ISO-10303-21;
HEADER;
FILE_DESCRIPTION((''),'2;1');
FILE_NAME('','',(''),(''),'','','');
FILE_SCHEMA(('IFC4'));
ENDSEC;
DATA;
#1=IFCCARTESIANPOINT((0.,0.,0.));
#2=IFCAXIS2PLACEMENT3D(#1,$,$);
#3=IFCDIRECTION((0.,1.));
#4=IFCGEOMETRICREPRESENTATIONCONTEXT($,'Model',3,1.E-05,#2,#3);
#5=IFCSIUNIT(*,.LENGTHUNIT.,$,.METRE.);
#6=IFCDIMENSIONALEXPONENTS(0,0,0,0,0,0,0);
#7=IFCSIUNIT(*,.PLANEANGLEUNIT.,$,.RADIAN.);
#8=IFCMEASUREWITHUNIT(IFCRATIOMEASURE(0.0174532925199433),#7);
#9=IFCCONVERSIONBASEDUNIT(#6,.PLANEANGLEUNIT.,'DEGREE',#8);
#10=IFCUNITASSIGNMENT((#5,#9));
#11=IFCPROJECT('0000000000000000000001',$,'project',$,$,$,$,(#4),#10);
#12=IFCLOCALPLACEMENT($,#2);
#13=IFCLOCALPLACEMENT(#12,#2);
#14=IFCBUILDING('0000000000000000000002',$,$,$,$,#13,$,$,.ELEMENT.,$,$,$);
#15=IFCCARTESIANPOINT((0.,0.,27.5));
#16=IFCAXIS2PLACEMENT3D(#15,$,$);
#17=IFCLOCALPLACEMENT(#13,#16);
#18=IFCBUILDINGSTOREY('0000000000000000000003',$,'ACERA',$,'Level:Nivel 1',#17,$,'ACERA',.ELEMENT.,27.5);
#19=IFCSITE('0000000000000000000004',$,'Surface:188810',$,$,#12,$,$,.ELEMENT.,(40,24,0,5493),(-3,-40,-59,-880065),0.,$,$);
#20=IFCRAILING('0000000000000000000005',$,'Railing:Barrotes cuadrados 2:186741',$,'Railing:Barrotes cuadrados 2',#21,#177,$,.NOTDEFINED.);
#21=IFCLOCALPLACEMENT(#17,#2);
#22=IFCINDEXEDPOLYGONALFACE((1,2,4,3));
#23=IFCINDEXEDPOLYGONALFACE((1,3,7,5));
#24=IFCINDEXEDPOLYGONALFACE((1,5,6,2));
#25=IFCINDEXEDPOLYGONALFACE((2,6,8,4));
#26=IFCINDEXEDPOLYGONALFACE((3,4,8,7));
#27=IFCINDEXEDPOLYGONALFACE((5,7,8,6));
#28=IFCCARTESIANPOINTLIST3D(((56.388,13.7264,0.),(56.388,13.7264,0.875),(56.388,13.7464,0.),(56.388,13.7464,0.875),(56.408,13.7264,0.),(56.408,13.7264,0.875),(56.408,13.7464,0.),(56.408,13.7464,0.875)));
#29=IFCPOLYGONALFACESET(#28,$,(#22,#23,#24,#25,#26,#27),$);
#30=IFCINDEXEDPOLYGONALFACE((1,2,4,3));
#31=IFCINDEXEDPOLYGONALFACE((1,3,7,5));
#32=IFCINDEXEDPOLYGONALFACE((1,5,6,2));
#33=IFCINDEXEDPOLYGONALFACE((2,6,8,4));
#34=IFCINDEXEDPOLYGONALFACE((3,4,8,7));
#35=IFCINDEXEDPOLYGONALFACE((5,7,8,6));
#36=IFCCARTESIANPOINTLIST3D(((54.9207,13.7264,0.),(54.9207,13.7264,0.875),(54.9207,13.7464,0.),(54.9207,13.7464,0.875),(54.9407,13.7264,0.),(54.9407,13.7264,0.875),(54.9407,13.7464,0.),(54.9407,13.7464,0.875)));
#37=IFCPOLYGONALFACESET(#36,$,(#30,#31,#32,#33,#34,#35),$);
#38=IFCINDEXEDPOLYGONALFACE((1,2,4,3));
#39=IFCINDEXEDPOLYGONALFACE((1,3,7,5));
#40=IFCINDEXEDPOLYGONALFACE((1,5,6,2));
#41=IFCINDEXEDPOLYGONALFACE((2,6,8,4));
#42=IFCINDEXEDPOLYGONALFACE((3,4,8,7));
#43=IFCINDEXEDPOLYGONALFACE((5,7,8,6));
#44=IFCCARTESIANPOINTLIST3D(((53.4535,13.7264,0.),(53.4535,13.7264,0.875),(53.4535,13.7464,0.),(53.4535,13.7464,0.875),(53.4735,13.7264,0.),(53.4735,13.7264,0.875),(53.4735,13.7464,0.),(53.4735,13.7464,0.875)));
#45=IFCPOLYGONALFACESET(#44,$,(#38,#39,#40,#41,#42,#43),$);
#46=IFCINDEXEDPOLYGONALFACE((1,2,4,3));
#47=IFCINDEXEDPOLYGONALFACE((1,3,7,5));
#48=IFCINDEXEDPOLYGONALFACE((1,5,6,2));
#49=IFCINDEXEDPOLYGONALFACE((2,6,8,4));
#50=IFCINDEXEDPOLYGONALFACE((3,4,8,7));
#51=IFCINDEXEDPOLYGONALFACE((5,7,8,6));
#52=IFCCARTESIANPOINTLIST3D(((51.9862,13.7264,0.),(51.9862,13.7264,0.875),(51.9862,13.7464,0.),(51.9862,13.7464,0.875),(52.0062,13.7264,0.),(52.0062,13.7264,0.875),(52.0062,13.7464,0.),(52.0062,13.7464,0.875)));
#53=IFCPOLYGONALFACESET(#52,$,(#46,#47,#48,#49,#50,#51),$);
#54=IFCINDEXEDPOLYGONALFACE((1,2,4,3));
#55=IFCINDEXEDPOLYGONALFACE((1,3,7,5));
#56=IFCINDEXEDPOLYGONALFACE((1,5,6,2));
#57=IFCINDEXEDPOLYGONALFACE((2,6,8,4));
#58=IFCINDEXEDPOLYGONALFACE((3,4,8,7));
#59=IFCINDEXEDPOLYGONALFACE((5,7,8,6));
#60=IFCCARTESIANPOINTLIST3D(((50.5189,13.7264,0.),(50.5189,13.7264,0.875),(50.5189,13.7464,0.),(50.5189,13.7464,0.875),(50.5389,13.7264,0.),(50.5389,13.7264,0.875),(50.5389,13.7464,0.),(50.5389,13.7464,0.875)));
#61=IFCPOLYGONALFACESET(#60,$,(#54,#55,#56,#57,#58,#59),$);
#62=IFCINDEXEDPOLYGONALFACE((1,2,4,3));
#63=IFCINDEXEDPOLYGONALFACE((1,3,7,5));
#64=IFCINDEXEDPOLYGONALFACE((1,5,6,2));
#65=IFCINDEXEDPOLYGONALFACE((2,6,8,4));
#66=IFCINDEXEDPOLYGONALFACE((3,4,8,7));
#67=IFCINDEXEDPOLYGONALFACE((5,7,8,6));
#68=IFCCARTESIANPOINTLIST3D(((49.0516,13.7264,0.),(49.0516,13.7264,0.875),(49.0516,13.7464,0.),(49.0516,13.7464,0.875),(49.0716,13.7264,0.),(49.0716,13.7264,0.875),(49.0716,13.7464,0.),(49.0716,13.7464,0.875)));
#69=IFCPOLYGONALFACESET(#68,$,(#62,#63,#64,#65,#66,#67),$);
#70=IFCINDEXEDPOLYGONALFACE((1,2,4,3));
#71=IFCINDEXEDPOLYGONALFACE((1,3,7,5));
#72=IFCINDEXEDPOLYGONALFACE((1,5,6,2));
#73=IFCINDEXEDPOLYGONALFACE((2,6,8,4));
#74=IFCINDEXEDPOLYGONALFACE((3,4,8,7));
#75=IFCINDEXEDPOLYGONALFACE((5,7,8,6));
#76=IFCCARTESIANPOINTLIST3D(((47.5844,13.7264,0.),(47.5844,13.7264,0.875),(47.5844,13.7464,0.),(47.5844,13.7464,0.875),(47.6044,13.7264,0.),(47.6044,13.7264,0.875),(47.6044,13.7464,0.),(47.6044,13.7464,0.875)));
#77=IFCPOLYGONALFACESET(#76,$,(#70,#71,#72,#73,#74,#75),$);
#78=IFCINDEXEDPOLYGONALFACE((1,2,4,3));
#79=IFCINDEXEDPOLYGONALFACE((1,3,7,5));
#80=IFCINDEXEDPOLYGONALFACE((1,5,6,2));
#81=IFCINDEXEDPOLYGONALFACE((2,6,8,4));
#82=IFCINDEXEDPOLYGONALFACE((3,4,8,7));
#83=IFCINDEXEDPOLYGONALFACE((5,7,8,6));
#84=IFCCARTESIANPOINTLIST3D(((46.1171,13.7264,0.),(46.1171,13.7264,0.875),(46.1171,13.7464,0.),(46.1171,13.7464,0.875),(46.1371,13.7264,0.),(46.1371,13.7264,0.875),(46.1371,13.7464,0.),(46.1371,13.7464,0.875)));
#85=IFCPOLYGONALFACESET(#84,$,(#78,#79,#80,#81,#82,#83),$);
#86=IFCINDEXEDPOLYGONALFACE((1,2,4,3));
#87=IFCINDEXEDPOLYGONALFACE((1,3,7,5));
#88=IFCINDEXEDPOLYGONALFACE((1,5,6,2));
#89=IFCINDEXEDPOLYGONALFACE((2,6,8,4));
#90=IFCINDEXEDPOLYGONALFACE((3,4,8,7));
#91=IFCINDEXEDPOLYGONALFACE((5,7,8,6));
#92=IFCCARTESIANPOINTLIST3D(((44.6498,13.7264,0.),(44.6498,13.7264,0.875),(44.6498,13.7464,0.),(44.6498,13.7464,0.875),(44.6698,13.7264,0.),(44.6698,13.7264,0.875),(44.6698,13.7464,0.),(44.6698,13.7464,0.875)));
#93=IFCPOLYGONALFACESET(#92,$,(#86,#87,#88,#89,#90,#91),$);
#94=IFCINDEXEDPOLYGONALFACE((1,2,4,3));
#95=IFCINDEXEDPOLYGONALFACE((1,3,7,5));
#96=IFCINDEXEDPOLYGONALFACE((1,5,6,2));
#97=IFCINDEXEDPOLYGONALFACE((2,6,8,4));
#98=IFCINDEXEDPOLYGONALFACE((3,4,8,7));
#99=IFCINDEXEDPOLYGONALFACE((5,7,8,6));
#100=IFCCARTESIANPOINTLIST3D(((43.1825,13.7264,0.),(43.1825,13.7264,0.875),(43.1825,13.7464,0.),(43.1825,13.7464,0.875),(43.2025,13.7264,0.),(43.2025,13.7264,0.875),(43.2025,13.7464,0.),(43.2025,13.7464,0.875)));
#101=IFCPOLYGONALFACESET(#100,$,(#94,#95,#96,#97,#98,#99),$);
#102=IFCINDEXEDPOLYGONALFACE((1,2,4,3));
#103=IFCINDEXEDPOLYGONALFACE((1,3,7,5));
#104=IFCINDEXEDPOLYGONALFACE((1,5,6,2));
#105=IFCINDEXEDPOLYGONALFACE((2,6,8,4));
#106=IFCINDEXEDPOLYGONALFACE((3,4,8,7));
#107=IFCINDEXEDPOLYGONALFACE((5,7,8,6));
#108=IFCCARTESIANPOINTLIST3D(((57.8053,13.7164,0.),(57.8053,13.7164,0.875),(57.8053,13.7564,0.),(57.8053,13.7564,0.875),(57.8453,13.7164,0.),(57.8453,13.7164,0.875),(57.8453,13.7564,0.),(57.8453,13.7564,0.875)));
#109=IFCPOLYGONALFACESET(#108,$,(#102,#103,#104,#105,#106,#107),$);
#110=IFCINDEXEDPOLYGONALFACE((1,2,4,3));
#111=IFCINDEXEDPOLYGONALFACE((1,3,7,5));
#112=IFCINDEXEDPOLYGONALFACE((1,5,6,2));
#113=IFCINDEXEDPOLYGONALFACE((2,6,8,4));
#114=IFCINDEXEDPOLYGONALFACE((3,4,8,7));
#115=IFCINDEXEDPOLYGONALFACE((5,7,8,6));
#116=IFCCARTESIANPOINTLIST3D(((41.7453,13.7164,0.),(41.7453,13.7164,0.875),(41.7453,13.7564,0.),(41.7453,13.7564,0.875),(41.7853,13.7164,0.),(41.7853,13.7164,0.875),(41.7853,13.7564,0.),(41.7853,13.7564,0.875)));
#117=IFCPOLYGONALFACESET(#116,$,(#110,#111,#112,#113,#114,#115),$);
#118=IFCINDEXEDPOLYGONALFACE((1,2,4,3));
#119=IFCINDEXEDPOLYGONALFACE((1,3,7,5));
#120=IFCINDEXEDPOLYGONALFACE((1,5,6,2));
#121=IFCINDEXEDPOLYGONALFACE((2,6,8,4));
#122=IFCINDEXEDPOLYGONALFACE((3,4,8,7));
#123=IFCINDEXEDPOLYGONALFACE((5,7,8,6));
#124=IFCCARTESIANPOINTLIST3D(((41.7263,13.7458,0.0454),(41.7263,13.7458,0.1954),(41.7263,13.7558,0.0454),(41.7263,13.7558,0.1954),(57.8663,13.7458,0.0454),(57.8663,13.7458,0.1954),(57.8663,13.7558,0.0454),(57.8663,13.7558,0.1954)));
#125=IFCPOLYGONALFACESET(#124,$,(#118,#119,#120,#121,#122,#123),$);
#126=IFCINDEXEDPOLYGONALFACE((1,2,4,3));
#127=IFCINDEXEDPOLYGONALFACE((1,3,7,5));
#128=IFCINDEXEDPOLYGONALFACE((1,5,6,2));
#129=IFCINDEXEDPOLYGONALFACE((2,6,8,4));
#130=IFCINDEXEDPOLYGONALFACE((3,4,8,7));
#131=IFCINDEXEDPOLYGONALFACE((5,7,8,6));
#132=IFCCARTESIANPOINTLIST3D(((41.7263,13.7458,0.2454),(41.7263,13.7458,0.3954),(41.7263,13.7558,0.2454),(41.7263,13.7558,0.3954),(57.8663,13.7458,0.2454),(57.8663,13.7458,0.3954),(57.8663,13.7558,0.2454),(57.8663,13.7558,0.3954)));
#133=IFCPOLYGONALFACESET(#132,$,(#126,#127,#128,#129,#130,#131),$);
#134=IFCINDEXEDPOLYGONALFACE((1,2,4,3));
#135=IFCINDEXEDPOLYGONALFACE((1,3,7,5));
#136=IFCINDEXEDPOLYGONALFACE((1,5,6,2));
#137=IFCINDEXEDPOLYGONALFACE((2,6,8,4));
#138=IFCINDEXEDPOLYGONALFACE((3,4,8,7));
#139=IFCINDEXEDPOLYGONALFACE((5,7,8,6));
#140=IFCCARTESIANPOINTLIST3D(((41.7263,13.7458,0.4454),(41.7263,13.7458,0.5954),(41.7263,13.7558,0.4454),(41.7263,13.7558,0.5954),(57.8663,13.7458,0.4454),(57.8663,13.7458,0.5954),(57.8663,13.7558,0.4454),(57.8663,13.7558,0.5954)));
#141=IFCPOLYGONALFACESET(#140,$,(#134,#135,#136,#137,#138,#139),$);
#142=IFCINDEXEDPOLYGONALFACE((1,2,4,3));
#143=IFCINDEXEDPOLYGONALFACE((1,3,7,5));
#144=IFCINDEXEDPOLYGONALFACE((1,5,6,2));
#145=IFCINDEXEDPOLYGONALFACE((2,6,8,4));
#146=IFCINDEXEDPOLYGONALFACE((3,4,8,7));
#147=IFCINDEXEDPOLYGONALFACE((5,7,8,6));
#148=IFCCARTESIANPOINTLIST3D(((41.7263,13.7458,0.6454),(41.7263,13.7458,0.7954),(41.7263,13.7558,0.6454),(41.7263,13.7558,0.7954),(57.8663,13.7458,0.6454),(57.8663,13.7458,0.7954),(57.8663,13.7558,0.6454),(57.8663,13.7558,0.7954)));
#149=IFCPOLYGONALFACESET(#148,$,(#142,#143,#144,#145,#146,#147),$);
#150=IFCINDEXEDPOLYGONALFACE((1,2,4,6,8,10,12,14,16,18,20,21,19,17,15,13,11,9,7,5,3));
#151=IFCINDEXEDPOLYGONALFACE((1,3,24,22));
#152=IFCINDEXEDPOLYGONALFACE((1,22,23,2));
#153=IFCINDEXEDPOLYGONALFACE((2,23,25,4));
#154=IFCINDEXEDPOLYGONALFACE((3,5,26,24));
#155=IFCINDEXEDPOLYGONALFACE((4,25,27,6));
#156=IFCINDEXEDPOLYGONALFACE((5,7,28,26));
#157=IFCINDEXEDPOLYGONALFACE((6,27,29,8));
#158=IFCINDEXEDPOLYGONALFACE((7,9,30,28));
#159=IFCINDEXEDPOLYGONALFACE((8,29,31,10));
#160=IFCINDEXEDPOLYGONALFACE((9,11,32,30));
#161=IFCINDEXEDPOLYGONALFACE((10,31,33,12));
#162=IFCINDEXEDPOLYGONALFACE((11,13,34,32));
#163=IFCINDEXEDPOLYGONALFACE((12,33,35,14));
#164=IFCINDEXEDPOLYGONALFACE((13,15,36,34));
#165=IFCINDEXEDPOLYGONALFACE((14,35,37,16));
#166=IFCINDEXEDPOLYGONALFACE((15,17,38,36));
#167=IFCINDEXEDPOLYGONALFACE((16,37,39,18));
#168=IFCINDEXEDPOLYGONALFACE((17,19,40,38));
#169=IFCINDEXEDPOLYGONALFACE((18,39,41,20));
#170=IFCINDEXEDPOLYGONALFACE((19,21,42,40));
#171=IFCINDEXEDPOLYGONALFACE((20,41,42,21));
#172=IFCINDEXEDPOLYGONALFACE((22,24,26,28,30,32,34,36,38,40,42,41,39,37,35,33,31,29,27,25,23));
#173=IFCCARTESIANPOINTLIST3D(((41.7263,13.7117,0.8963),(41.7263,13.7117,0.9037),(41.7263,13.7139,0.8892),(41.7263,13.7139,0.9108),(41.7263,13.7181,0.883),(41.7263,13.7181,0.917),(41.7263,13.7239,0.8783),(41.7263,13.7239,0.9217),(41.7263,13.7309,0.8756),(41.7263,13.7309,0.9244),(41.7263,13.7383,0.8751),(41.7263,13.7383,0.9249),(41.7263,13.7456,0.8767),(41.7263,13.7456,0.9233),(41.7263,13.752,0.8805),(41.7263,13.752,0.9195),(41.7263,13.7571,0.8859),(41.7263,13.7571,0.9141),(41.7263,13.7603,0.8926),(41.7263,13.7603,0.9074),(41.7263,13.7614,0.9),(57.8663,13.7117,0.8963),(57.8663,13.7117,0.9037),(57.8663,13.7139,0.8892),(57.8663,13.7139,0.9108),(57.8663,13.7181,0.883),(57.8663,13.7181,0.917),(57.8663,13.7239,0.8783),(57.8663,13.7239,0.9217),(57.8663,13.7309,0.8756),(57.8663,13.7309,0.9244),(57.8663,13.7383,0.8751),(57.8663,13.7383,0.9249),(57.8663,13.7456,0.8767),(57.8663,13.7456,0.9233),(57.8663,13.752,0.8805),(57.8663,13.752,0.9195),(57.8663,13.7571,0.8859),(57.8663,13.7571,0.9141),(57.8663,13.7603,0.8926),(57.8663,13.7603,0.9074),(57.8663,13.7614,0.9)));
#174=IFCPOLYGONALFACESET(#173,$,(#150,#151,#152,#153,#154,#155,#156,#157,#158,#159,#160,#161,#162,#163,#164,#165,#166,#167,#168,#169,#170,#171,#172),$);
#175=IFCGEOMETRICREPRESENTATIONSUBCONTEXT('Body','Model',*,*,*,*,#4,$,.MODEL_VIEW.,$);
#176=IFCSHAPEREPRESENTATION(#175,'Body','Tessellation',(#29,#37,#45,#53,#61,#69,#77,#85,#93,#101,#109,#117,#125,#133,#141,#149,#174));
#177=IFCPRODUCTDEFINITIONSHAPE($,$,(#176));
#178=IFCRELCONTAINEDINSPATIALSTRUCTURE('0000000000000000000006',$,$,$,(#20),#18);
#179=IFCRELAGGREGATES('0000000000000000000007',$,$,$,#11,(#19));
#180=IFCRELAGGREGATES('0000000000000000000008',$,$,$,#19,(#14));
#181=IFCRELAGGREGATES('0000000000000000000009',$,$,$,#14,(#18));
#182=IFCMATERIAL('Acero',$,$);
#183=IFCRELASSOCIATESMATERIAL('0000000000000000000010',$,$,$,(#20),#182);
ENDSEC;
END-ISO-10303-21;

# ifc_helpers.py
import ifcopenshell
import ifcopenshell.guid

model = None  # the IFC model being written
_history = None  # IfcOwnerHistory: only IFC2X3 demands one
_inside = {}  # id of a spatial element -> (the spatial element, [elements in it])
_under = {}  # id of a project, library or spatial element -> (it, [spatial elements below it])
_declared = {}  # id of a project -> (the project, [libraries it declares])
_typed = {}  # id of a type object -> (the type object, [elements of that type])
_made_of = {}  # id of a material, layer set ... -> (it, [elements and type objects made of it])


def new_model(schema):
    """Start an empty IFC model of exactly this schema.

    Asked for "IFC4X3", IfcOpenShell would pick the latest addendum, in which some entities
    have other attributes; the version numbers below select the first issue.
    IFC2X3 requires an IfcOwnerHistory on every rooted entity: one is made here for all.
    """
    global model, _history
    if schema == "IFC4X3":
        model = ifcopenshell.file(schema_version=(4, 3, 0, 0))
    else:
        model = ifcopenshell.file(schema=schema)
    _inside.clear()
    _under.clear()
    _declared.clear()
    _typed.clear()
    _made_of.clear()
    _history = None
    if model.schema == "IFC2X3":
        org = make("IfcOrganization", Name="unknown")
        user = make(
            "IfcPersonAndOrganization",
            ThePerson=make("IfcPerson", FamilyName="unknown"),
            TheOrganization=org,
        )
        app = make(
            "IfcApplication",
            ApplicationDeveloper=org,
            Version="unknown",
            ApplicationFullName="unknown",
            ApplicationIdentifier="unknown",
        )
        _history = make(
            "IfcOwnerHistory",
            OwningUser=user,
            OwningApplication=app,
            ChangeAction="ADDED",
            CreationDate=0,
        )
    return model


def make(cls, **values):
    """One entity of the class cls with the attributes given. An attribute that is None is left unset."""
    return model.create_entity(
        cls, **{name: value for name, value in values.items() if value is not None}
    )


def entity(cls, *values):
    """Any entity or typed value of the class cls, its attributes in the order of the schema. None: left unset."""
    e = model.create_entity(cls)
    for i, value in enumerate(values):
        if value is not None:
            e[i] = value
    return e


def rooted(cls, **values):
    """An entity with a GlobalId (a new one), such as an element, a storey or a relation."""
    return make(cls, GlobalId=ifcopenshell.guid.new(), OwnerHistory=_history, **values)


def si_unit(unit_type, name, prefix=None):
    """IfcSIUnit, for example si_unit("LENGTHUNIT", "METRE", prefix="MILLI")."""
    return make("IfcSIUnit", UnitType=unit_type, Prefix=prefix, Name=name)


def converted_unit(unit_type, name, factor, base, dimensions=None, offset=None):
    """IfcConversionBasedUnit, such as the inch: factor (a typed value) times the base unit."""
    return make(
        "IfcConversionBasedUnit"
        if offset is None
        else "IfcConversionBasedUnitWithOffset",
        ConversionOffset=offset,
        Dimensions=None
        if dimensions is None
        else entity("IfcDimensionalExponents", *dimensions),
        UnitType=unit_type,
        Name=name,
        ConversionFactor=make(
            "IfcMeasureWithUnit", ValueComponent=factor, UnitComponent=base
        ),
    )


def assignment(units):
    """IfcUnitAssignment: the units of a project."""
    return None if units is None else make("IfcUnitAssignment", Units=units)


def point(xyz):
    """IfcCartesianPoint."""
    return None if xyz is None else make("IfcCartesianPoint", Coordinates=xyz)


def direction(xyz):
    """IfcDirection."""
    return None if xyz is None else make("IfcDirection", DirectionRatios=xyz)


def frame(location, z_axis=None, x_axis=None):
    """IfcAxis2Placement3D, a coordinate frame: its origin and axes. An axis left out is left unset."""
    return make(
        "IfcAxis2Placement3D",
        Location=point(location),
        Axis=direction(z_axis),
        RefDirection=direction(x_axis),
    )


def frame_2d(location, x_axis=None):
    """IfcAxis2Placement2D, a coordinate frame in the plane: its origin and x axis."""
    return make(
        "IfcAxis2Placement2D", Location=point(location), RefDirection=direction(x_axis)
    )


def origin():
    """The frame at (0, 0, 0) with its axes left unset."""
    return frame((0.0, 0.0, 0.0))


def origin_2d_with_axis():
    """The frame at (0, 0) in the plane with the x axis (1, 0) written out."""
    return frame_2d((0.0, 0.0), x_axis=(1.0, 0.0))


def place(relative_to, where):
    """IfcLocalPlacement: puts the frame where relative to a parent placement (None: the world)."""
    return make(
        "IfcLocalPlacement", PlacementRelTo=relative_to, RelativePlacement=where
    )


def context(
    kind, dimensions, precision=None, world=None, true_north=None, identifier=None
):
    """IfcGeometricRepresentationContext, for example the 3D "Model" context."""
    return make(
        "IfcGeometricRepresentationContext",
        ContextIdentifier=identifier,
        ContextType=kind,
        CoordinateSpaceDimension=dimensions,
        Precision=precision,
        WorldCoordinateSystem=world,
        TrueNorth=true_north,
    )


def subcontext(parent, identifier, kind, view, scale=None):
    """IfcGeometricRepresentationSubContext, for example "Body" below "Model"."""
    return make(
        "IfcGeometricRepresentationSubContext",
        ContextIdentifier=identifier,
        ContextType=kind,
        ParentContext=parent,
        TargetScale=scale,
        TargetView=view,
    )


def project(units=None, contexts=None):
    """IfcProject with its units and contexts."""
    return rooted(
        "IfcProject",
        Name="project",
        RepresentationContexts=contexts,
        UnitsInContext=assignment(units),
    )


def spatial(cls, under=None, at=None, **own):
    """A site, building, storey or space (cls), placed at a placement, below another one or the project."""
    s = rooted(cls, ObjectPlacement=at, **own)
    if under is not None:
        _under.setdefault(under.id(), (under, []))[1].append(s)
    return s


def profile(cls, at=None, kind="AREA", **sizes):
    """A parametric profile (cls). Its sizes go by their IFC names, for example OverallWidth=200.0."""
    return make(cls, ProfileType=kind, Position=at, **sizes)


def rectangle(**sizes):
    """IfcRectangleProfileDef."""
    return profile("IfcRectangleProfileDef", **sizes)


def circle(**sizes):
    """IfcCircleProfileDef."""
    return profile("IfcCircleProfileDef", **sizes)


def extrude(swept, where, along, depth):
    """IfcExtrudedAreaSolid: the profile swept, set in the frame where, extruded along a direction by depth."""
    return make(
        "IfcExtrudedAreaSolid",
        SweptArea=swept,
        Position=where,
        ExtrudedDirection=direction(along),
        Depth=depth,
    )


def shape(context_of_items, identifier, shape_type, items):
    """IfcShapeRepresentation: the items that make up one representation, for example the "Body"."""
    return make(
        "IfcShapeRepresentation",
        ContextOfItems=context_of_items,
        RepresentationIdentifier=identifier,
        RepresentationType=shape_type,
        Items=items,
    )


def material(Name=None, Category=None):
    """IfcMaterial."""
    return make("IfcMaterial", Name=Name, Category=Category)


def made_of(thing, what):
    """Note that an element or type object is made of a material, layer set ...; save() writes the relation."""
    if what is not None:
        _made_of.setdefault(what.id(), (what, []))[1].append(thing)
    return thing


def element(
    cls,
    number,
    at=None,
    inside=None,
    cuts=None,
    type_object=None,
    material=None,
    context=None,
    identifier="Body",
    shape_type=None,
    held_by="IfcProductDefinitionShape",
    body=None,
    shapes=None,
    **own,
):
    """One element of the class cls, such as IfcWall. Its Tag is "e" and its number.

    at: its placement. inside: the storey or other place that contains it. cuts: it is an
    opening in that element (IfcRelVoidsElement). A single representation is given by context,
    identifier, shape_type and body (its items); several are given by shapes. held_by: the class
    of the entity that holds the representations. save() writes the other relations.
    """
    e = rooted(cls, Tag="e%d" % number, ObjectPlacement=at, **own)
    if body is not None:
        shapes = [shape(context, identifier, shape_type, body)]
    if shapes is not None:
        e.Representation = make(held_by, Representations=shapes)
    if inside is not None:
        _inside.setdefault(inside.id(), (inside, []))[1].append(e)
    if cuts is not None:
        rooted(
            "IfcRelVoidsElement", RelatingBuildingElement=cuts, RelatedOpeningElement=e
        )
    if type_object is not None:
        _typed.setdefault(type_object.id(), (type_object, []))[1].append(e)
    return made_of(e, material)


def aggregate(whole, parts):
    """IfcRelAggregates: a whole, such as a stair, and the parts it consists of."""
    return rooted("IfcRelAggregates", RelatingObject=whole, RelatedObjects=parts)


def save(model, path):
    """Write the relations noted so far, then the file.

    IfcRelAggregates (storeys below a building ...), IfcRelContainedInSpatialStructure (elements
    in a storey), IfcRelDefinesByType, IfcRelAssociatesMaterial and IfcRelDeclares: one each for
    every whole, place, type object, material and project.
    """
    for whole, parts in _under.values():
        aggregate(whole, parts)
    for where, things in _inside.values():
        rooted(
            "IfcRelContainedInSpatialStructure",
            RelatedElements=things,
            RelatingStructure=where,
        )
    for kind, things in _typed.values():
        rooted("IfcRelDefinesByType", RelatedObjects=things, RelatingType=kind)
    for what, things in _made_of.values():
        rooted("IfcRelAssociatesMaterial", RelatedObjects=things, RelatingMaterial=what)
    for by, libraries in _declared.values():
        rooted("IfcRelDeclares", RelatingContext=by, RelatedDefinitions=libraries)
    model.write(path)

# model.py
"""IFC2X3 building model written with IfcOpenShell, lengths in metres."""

from ifc_helpers import new_model, entity, si_unit, converted_unit, direction, frame, frame_2d, origin, origin_2d_with_axis, place, context, subcontext, project, spatial, rectangle, circle, extrude, material, element, save


model = new_model("IFC2X3")

# Units and contexts
model_context = context("Model", 3, precision=1e-05, world=origin(), true_north=direction((0.0, 1.0)))
body_context = subcontext(model_context, "Body", "Model", "MODEL_VIEW")
ifc_project = project(units=[si_unit("LENGTHUNIT", "METRE"), converted_unit("PLANEANGLEUNIT", "DEGREE", entity("IfcRatioMeasure", 0.0174532925199433), si_unit("PLANEANGLEUNIT", "RADIAN"), dimensions=[0, 0, 0, 0, 0, 0, 0])], contexts=[model_context])

# Site, building, storey
site_placement = place(None, origin())
site = spatial("IfcSite", under=ifc_project, at=site_placement, Name="Surface:188810", CompositionType="ELEMENT", RefLatitude=(40, 24, 0, 5493), RefLongitude=(-3, -40, -59, -880065), RefElevation=0.0)
building_placement = place(site_placement, origin())
building = spatial("IfcBuilding", under=site, at=building_placement, CompositionType="ELEMENT")
storey_placement = place(building_placement, frame((0.0, 0.0, 27.5)))
storey = spatial("IfcBuildingStorey", under=building, at=storey_placement, Name="ACERA", ObjectType="Level:Nivel 1", LongName="ACERA", CompositionType="ELEMENT", Elevation=27.5)

# Railing
ifc_material_1 = material(Name="Acero")
railing_1_placement = place(storey_placement, origin())
element("IfcRailing", 1, at=railing_1_placement, inside=storey, material=ifc_material_1, Name="Railing:Barrotes cuadrados 2:186741", ObjectType="Railing:Barrotes cuadrados 2", PredefinedType="NOTDEFINED", context=body_context, shape_type="SweptSolid", body=[
    extrude(rectangle(XDim=0.02, YDim=0.02, at=frame_2d((0.0, 0.0), x_axis=(1.0, 0.0))), frame((56.398, 13.7364, 0.0)), (0.0, 0.0, 1.0), 0.875),
    extrude(rectangle(XDim=0.02, YDim=0.02, at=frame_2d((0.0, 0.0), x_axis=(1.0, 0.0))), frame((54.9307, 13.7364, 0.0)), (0.0, 0.0, 1.0), 0.875),
    extrude(rectangle(XDim=0.02, YDim=0.02, at=frame_2d((0.0, 0.0), x_axis=(1.0, 0.0))), frame((53.4635, 13.7364, 0.0)), (0.0, 0.0, 1.0), 0.875),
    extrude(rectangle(XDim=0.02, YDim=0.02, at=frame_2d((0.0, 0.0), x_axis=(1.0, 0.0))), frame((51.9962, 13.7364, 0.0)), (0.0, 0.0, 1.0), 0.875),
    extrude(rectangle(XDim=0.02, YDim=0.02, at=frame_2d((0.0, 0.0), x_axis=(1.0, 0.0))), frame((50.5289, 13.7364, 0.0)), (0.0, 0.0, 1.0), 0.875),
    extrude(rectangle(XDim=0.02, YDim=0.02, at=frame_2d((0.0, 0.0), x_axis=(1.0, 0.0))), frame((49.0616, 13.7364, 0.0)), (0.0, 0.0, 1.0), 0.875),
    extrude(rectangle(XDim=0.02, YDim=0.02, at=frame_2d((0.0, 0.0), x_axis=(1.0, 0.0))), frame((47.5944, 13.7364, 0.0)), (0.0, 0.0, 1.0), 0.875),
    extrude(rectangle(XDim=0.02, YDim=0.02, at=frame_2d((0.0, 0.0), x_axis=(1.0, 0.0))), frame((46.1271, 13.7364, 0.0)), (0.0, 0.0, 1.0), 0.875),
    extrude(rectangle(XDim=0.02, YDim=0.02, at=frame_2d((0.0, 0.0), x_axis=(1.0, 0.0))), frame((44.6598, 13.7364, 0.0)), (0.0, 0.0, 1.0), 0.875),
    extrude(rectangle(XDim=0.02, YDim=0.02, at=frame_2d((0.0, 0.0), x_axis=(1.0, 0.0))), frame((43.1925, 13.7364, 0.0)), (0.0, 0.0, 1.0), 0.875),
    extrude(rectangle(XDim=0.04, YDim=0.04, at=frame_2d((0.0, 0.0), x_axis=(1.0, 0.0))), frame((57.8253, 13.7364, 0.0)), (0.0, 0.0, 1.0), 0.875),
    extrude(rectangle(XDim=0.04, YDim=0.04, at=frame_2d((0.0, 0.0), x_axis=(1.0, 0.0))), frame((41.7653, 13.7364, 0.0)), (0.0, 0.0, 1.0), 0.875),
    extrude(rectangle(XDim=16.14, YDim=0.01, at=frame_2d((0.0, 0.0), x_axis=(1.0, 0.0))), frame((49.7963, 13.7508, 0.0454)), (0.0, 0.0, 1.0), 0.15),
    extrude(rectangle(XDim=16.14, YDim=0.01, at=frame_2d((0.0, 0.0), x_axis=(1.0, 0.0))), frame((49.7963, 13.7508, 0.2454)), (0.0, 0.0, 1.0), 0.15),
    extrude(rectangle(XDim=16.14, YDim=0.01, at=frame_2d((0.0, 0.0), x_axis=(1.0, 0.0))), frame((49.7963, 13.7508, 0.4454)), (0.0, 0.0, 1.0), 0.15),
    extrude(rectangle(XDim=16.14, YDim=0.01, at=frame_2d((0.0, 0.0), x_axis=(1.0, 0.0))), frame((49.7963, 13.7508, 0.6454)), (0.0, 0.0, 1.0), 0.15),
    extrude(circle(Radius=0.025, at=origin_2d_with_axis()), frame((41.7263, 13.7364, 0.9), z_axis=(1.0, 0.0, 0.0), x_axis=(0.0, 1.0, 0.0)), (0.0, 0.0, 1.0), 16.14),
])

save(model, "model.ifc")
